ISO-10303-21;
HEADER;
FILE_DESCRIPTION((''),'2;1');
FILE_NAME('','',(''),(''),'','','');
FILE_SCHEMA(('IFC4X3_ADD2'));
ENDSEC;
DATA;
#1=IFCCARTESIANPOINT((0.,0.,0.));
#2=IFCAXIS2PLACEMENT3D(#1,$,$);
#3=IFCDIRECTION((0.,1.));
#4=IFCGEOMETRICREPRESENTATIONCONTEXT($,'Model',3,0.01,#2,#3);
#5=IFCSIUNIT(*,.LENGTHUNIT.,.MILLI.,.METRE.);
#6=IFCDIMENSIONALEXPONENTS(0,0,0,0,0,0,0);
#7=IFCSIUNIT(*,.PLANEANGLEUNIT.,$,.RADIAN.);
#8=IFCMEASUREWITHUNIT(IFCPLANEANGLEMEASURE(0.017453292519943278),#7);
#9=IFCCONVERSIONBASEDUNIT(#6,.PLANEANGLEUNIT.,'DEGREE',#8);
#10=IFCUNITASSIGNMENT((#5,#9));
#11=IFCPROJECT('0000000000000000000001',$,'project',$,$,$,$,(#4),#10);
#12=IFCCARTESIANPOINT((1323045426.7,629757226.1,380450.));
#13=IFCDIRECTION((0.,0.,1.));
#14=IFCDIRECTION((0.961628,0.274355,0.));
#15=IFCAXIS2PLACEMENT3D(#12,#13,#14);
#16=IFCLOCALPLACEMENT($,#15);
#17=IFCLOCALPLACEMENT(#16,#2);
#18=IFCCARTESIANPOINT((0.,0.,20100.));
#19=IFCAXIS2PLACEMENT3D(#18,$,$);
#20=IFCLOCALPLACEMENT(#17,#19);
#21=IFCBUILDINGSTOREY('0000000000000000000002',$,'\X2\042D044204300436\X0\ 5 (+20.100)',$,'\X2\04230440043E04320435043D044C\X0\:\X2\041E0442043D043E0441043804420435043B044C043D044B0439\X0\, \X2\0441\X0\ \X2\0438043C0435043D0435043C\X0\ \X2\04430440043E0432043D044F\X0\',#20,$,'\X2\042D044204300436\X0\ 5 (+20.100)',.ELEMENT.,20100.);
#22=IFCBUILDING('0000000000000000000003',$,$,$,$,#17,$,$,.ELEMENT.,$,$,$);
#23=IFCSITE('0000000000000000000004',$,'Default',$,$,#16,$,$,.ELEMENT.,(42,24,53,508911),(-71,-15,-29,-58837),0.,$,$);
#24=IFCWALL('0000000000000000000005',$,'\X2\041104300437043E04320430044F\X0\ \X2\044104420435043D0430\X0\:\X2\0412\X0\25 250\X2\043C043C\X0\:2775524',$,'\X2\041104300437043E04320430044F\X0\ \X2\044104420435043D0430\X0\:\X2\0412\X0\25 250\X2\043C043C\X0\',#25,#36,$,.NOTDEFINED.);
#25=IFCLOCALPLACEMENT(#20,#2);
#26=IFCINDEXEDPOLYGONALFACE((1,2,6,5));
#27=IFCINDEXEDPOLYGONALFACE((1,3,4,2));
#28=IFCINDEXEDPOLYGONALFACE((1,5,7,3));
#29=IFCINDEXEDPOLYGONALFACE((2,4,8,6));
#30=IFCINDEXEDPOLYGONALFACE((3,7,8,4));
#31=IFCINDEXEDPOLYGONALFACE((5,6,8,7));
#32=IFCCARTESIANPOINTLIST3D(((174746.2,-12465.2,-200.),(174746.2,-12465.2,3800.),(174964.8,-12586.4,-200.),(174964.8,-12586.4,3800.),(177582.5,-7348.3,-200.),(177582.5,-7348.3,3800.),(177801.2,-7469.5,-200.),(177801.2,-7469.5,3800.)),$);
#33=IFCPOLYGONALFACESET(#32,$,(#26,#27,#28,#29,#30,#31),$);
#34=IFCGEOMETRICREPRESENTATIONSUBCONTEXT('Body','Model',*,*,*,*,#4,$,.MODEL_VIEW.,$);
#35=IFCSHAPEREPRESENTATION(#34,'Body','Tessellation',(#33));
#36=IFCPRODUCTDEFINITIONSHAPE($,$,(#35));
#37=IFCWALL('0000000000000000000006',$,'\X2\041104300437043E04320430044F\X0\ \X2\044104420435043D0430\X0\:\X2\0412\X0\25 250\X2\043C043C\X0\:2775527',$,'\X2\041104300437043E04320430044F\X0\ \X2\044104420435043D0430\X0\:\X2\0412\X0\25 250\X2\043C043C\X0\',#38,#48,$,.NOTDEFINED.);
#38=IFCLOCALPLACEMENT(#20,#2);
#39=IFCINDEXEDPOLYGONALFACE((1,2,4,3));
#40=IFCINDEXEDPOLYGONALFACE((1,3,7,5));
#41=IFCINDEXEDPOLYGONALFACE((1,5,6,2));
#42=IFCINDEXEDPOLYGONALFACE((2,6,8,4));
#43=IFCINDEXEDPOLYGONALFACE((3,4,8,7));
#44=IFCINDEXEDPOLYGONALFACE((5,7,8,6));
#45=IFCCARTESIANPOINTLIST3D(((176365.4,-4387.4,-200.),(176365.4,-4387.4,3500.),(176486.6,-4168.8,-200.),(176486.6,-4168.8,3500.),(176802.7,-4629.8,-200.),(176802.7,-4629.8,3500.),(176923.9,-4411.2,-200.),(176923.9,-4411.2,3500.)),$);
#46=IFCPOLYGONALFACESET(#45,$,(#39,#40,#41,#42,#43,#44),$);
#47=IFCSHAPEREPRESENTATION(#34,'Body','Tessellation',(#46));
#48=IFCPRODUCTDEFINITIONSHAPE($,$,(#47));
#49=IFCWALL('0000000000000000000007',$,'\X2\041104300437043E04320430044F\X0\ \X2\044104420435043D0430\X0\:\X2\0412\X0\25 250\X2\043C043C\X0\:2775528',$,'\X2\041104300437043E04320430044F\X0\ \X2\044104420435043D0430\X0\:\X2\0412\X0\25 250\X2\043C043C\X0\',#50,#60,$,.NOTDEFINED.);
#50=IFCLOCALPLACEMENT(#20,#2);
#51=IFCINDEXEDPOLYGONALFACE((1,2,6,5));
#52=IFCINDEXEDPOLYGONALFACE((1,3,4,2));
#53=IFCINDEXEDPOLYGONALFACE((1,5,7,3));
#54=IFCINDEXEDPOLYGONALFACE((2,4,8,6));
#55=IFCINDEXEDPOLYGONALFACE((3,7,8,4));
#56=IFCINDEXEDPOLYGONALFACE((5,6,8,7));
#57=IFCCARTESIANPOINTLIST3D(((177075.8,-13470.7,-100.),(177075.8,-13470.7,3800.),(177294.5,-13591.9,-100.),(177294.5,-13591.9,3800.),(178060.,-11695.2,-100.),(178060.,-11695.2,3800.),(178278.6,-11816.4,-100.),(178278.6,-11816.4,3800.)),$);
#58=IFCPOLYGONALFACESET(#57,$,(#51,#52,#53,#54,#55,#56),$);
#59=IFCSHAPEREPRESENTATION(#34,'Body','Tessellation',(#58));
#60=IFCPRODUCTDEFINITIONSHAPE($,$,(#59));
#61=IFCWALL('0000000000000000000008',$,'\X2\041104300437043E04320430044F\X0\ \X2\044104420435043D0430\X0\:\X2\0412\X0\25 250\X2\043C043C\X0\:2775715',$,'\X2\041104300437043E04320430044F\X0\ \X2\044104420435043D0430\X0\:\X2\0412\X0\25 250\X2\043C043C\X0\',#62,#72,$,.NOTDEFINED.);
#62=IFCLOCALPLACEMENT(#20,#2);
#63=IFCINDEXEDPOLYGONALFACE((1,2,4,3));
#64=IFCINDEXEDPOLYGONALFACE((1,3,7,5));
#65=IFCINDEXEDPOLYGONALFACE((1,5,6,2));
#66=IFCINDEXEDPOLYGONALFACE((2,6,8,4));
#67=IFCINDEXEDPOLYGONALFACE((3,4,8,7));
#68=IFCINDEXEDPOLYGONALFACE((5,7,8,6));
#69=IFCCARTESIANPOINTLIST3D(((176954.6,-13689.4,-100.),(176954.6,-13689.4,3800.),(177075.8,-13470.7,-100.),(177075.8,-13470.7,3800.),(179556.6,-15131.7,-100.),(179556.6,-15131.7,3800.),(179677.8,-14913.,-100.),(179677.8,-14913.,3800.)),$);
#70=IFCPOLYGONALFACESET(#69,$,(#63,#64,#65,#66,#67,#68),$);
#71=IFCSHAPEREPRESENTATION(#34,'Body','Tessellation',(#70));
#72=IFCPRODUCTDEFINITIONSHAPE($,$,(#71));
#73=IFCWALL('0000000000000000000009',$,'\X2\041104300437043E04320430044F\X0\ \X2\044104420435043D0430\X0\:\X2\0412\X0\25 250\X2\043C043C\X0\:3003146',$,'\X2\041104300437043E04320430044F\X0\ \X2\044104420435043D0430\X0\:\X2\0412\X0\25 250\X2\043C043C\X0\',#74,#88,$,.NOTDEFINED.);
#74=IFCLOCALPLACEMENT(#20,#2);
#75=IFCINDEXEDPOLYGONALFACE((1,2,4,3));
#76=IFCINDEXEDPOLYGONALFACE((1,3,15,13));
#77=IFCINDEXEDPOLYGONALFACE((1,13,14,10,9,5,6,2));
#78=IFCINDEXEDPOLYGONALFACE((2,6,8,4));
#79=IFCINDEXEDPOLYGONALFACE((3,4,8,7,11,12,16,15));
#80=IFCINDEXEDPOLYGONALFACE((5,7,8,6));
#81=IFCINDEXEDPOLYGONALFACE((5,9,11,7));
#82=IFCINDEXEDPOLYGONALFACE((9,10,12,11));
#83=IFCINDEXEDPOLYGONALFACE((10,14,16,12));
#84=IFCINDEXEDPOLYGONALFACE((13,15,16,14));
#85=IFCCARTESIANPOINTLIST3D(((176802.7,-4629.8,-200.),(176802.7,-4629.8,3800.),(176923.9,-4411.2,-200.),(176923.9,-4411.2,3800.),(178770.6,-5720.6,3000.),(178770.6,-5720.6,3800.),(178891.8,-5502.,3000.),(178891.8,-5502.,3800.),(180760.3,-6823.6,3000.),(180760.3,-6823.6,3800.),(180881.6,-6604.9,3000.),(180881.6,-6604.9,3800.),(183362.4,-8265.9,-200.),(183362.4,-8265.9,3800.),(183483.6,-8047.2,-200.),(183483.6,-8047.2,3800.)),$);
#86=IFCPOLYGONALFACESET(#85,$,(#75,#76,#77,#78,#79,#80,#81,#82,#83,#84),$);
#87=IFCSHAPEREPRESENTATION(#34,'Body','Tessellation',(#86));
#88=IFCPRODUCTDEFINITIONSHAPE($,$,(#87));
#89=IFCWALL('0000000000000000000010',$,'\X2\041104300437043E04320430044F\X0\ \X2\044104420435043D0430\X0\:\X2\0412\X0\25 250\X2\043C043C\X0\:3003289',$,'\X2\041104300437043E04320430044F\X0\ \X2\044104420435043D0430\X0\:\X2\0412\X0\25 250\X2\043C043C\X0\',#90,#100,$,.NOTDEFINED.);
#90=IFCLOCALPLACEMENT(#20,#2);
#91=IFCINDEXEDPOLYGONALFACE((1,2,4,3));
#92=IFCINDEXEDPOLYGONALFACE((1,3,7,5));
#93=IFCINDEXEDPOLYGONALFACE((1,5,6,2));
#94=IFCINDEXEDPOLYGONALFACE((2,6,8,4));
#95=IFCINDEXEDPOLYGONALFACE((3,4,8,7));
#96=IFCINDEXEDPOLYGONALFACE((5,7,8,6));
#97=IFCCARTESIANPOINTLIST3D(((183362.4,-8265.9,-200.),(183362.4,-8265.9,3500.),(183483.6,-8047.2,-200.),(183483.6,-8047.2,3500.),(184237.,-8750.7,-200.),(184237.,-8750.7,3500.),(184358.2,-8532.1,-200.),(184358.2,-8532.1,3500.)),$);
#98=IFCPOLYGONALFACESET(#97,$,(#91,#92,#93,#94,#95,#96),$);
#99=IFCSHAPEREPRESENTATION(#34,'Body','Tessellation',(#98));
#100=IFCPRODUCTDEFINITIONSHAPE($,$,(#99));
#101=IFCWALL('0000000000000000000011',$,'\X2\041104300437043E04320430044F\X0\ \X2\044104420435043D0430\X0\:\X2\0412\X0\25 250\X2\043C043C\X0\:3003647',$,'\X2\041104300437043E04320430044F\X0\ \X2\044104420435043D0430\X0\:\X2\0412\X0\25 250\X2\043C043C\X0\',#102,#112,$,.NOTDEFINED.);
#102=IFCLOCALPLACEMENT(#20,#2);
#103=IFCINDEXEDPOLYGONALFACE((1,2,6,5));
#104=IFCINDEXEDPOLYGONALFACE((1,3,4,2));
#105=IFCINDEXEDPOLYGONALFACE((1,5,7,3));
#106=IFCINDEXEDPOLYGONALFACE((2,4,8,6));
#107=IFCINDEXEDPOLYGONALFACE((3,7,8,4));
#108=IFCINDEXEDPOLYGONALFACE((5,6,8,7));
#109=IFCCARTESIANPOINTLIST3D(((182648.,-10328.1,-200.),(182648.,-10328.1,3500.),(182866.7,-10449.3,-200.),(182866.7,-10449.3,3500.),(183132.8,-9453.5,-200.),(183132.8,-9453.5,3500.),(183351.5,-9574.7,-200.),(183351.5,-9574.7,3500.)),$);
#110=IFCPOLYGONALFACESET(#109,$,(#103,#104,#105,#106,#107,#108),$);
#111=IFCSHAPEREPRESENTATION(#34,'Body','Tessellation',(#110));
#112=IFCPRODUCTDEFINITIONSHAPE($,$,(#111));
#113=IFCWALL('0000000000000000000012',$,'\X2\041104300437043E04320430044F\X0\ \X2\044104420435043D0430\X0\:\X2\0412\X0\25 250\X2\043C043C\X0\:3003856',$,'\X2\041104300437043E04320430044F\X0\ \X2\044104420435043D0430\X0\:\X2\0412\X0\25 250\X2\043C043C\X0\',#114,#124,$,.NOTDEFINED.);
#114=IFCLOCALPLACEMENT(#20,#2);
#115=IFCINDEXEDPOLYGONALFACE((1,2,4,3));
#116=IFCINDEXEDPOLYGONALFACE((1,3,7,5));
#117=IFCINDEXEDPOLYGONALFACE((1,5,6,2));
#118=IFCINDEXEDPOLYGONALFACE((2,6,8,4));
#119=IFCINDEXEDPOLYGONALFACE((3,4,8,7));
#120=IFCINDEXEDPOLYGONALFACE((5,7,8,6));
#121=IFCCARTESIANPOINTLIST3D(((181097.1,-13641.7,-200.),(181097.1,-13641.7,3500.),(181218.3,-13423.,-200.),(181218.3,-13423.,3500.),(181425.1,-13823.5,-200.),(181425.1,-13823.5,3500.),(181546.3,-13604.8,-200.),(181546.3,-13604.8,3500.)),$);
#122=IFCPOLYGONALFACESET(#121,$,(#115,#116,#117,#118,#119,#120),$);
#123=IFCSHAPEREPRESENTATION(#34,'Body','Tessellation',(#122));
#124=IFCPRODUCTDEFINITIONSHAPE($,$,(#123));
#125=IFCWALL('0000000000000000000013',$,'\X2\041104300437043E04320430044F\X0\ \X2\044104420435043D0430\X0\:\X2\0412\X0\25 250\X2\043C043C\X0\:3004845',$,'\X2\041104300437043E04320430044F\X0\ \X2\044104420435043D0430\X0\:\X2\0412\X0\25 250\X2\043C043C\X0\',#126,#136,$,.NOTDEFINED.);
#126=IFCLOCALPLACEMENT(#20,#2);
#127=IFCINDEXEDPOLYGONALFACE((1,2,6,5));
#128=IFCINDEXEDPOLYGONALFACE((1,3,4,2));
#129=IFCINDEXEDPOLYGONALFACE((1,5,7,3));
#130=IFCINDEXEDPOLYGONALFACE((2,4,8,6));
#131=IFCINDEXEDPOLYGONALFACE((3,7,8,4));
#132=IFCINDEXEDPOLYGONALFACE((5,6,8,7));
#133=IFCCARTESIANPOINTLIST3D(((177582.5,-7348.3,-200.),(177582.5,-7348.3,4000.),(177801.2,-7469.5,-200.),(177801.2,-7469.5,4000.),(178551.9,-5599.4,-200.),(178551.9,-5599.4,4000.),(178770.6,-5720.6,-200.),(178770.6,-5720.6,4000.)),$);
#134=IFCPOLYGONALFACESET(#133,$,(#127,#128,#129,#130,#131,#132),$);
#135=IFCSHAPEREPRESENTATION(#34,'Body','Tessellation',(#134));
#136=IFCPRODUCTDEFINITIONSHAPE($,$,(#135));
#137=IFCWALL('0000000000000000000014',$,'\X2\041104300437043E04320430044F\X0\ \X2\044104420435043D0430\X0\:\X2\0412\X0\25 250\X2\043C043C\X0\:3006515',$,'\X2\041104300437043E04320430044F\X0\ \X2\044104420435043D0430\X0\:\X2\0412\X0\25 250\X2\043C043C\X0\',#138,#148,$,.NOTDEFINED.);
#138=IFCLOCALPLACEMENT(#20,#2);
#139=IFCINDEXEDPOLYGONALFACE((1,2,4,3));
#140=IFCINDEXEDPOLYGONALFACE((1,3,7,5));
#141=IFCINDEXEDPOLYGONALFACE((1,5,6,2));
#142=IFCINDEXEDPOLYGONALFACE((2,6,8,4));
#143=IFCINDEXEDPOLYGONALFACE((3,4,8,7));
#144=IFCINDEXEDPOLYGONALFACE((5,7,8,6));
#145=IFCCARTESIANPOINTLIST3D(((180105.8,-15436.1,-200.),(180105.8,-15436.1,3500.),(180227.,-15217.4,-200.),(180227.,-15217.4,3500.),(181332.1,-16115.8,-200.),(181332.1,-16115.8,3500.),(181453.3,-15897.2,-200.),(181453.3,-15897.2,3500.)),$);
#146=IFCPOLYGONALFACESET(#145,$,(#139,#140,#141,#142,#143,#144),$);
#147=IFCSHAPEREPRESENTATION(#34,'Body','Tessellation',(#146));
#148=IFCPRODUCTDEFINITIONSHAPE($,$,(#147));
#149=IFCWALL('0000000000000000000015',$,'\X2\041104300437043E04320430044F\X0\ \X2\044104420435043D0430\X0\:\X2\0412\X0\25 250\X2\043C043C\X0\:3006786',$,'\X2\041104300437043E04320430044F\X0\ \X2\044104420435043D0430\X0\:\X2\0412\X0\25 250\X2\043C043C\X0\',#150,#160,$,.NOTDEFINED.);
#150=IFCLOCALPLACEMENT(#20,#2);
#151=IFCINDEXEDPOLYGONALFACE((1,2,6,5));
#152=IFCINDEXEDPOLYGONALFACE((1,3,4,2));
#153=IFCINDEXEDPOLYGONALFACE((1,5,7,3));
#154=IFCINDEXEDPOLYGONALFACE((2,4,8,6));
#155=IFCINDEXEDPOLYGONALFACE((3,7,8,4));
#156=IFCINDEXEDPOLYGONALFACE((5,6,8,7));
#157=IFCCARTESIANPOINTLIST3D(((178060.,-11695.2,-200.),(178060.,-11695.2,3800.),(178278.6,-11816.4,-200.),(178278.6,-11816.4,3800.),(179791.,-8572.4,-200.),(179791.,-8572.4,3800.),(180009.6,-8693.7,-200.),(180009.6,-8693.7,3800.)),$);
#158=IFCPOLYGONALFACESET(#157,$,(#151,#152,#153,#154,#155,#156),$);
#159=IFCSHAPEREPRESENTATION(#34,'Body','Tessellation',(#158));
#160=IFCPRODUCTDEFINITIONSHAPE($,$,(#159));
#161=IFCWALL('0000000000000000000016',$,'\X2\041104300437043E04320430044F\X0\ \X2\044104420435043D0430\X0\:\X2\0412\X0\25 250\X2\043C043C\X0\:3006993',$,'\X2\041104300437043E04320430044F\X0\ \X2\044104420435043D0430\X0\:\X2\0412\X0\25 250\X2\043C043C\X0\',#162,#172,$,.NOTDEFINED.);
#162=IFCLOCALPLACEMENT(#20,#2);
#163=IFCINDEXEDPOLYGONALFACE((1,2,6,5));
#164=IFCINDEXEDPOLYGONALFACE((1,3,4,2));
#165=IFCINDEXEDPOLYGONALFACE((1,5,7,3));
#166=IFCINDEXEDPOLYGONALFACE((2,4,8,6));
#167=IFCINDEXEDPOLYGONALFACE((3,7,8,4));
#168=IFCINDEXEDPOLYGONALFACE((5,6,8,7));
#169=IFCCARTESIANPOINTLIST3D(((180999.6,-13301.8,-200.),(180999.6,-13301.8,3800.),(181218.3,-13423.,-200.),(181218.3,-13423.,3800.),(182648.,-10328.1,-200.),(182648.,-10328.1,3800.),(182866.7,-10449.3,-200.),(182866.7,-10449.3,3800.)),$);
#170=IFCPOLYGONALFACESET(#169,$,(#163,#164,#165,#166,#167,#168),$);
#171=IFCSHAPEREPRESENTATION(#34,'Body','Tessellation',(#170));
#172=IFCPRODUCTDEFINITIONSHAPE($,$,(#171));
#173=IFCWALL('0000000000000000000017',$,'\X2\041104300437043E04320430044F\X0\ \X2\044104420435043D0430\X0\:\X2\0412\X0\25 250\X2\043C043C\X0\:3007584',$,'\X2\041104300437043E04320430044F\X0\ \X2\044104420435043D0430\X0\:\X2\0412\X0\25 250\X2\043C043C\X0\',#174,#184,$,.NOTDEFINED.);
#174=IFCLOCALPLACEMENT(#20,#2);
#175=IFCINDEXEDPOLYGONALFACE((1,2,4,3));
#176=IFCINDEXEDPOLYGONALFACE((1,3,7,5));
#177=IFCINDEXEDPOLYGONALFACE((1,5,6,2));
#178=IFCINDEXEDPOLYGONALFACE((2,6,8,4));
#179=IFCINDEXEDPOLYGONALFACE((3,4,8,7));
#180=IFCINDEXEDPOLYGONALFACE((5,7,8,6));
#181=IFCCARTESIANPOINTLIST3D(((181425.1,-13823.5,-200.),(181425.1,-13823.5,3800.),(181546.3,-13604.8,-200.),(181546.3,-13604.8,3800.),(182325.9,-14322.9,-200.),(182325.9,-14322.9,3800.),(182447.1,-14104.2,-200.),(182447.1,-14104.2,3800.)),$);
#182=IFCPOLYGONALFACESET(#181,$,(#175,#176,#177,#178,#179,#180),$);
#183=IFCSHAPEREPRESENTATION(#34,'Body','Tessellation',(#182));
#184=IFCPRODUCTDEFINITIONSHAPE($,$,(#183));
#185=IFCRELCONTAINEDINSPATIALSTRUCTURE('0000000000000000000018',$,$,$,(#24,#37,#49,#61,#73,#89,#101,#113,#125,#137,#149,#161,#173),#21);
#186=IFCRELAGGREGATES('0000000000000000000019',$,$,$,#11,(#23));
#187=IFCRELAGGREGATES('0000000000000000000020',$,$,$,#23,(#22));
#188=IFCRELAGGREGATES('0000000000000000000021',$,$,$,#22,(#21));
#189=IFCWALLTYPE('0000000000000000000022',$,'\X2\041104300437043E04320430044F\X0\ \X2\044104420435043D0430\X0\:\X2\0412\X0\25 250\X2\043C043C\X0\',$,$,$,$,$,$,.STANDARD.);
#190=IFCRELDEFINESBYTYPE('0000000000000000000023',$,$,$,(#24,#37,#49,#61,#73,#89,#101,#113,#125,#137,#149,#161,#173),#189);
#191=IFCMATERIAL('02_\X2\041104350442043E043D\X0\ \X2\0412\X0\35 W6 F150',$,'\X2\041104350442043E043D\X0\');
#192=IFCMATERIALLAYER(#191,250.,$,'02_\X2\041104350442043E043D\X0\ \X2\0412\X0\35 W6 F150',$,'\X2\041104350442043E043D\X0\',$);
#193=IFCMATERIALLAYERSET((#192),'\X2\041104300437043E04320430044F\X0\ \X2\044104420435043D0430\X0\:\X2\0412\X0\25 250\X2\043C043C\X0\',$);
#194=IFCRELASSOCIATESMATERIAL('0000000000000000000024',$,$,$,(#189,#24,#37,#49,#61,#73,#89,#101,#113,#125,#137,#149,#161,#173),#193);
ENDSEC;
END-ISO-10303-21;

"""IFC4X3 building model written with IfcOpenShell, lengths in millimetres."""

from ifc_helpers import new_model, entity, si_unit, converted_unit, direction, frame, frame_2d, origin, place, context, subcontext, project, spatial, polyline, rectangle, extrude, clip, bounded_halfspace, material, layer, layer_set, type_object, element, save


model = new_model("IFC4X3")

# Units and contexts
model_context = context("Model", 3, precision=0.01, world=origin(), true_north=direction((0.0, 1.0)))
body_context = subcontext(model_context, "Body", "Model", "MODEL_VIEW")
ifc_project = project(units=[si_unit("LENGTHUNIT", "METRE", prefix="MILLI"), converted_unit("PLANEANGLEUNIT", "DEGREE", entity("IfcPlaneAngleMeasure", 0.017453292519943278), si_unit("PLANEANGLEUNIT", "RADIAN"), dimensions=[0, 0, 0, 0, 0, 0, 0])], contexts=[model_context])

# Site, building, storey
site_placement = place(None, frame((1323045426.7, 629757226.1, 380450.0), z_axis=(0.0, 0.0, 1.0), x_axis=(0.961628, 0.274355, 0.0)))
site = spatial("IfcSite", under=ifc_project, at=site_placement, Name="Default", CompositionType="ELEMENT", RefLatitude=(42, 24, 53, 508911), RefLongitude=(-71, -15, -29, -58837), RefElevation=0.0)
building_placement = place(site_placement, origin())
building = spatial("IfcBuilding", under=site, at=building_placement, CompositionType="ELEMENT")
storey_placement = place(building_placement, frame((0.0, 0.0, 20100.0)))
storey = spatial("IfcBuildingStorey", under=building, at=storey_placement, Name="Этаж 5 (+20.100)", ObjectType="Уровень:Относительный, с именем уровня", LongName="Этаж 5 (+20.100)", CompositionType="ELEMENT", Elevation=20100.0)

# Walls
ifc_material_1 = material(Name="02_Бетон В35 W6 F150", Category="Бетон")
ifc_layer_1 = layer(ifc_material_1, 250.0, Name="02_Бетон В35 W6 F150", Category="Бетон")
ifc_layer_set_1 = layer_set([ifc_layer_1], Name="Базовая стена:В25 250мм")
wall_type_1 = type_object("IfcWallType", Name="Базовая стена:В25 250мм", PredefinedType="STANDARD", material=ifc_layer_set_1)
wall_1_placement = place(storey_placement, frame((174855.5, -12525.8, -200.0), z_axis=(0.0, 0.0, 1.0), x_axis=(0.48481, 0.87462, 0.0)))
element("IfcWall", 1, at=wall_1_placement, inside=storey, type_object=wall_type_1, material=ifc_layer_set_1, Name="Базовая стена:В25 250мм:2775524", ObjectType="Базовая стена:В25 250мм", PredefinedType="NOTDEFINED", context=body_context, shape_type="SweptSolid", body=[
    extrude(rectangle(XDim=5850.4, YDim=250.0, at=frame_2d((2925.2, 0.0), x_axis=(-1.0, 0.0))), origin(), (0.0, 0.0, 1.0), 4000.0),
])
wall_2_placement = place(storey_placement, frame((176426.0, -4278.1, -200.0), z_axis=(0.0, 0.0, 1.0), x_axis=(0.87462, -0.48481, 0.0)))
element("IfcWall", 2, at=wall_2_placement, inside=storey, type_object=wall_type_1, material=ifc_layer_set_1, Name="Базовая стена:В25 250мм:2775527", ObjectType="Базовая стена:В25 250мм", PredefinedType="NOTDEFINED", context=body_context, shape_type="SweptSolid", body=[
    extrude(rectangle(XDim=500.0, YDim=250.0, at=frame_2d((250.0, 0.0), x_axis=(-1.0, 0.0))), origin(), (0.0, 0.0, 1.0), 3700.0),
])
wall_3_placement = place(storey_placement, frame((177185.1, -13531.3, -100.0), z_axis=(0.0, 0.0, 1.0), x_axis=(0.48481, 0.87462, 0.0)))
element("IfcWall", 3, at=wall_3_placement, inside=storey, type_object=wall_type_1, material=ifc_layer_set_1, Name="Базовая стена:В25 250мм:2775528", ObjectType="Базовая стена:В25 250мм", PredefinedType="NOTDEFINED", context=body_context, shape_type="SweptSolid", body=[
    extrude(rectangle(XDim=2030.0, YDim=250.0, at=frame_2d((1015.0, 0.0), x_axis=(-1.0, 0.0))), origin(), (0.0, 0.0, 1.0), 3900.0),
])
wall_4_placement = place(storey_placement, frame((177015.2, -13580.0, -100.0), z_axis=(0.0, 0.0, 1.0), x_axis=(0.87462, -0.48481, 0.0)))
element("IfcWall", 4, at=wall_4_placement, inside=storey, type_object=wall_type_1, material=ifc_layer_set_1, Name="Базовая стена:В25 250мм:2775715", ObjectType="Базовая стена:В25 250мм", PredefinedType="NOTDEFINED", context=body_context, shape_type="SweptSolid", body=[
    extrude(rectangle(XDim=2975.0, YDim=250.0, at=frame_2d((1487.5, 0.0), x_axis=(-1.0, 0.0))), origin(), (0.0, 0.0, 1.0), 3900.0),
])

# Wall, opening
wall_5_placement = place(storey_placement, frame((176863.3, -4520.5, -200.0), z_axis=(0.0, 0.0, 1.0), x_axis=(0.87462, -0.48481, 0.0)))
wall_5 = element("IfcWall", 5, at=wall_5_placement, inside=storey, type_object=wall_type_1, material=ifc_layer_set_1, Name="Базовая стена:В25 250мм:3003146", ObjectType="Базовая стена:В25 250мм", PredefinedType="NOTDEFINED", context=body_context, shape_type="SweptSolid", body=[
    extrude(rectangle(XDim=7500.0, YDim=250.0, at=frame_2d((3750.0, 0.0), x_axis=(-1.0, 0.0))), origin(), (0.0, 0.0, 1.0), 4000.0),
])
opening_1_placement = place(wall_5_placement, frame((-156879.7, -81791.3, 3200.0), z_axis=(0.0, 0.0, 1.0), x_axis=(0.87462, 0.48481, 0.0)))
element("IfcOpeningElement", 6, at=opening_1_placement, cuts=wall_5, PredefinedType="OPENING", context=body_context, shape_type="SweptSolid", body=[
    extrude(rectangle(XDim=800.0, YDim=2275.0, at=frame_2d((0.0, 0.0), x_axis=(1.0, 0.0))), frame((179147.8, -7386.4, 400.0), z_axis=(0.48481, 0.87462, 0.0), x_axis=(0.0, 0.0, -1.0)), (0.0, 0.0, 1.0), 3048.0),
])

# Wall
wall_6_placement = place(storey_placement, frame((183423.0, -8156.6, -200.0), z_axis=(0.0, 0.0, 1.0), x_axis=(0.87462, -0.48481, 0.0)))
element("IfcWall", 7, at=wall_6_placement, inside=storey, type_object=wall_type_1, material=ifc_layer_set_1, Name="Базовая стена:В25 250мм:3003289", ObjectType="Базовая стена:В25 250мм", PredefinedType="NOTDEFINED", context=body_context, shape_type="SweptSolid", body=[
    extrude(rectangle(XDim=1000.0, YDim=250.0, at=frame_2d((500.0, 0.0), x_axis=(-1.0, 0.0))), origin(), (0.0, 0.0, 1.0), 3700.0),
])

# Walls
wall_7_placement = place(storey_placement, frame((182757.3, -10388.7, -200.0), z_axis=(0.0, 0.0, 1.0), x_axis=(0.48481, 0.87462, 0.0)))
element("IfcWall", 8, at=wall_7_placement, inside=storey, type_object=wall_type_1, material=ifc_layer_set_1, Name="Базовая стена:В25 250мм:3003647", ObjectType="Базовая стена:В25 250мм", PredefinedType="NOTDEFINED", context=body_context, shape_type="SweptSolid", body=[
    extrude(rectangle(XDim=1000.0, YDim=250.0, at=frame_2d((500.0, 0.0), x_axis=(-1.0, 0.0))), origin(), (0.0, 0.0, 1.0), 3700.0),
])
wall_8_placement = place(storey_placement, frame((181157.7, -13532.4, -200.0), z_axis=(0.0, 0.0, 1.0), x_axis=(0.87462, -0.48481, 0.0)))
element("IfcWall", 9, at=wall_8_placement, inside=storey, type_object=wall_type_1, material=ifc_layer_set_1, Name="Базовая стена:В25 250мм:3003856", ObjectType="Базовая стена:В25 250мм", PredefinedType="NOTDEFINED", context=body_context, shape_type="SweptSolid", body=[
    extrude(rectangle(XDim=375.0, YDim=250.0, at=frame_2d((187.5, 0.0), x_axis=(-1.0, 0.0))), origin(), (0.0, 0.0, 1.0), 3700.0),
])

# Wall
wall_9_placement = place(storey_placement, frame((177691.9, -7408.9, -200.0), z_axis=(0.0, 0.0, 1.0), x_axis=(0.48481, 0.87462, 0.0)))
element("IfcWall", 10, at=wall_9_placement, inside=storey, type_object=wall_type_1, material=ifc_layer_set_1, Name="Базовая стена:В25 250мм:3004845", ObjectType="Базовая стена:В25 250мм", PredefinedType="NOTDEFINED", context=body_context, shape_type="SweptSolid", body=[
    extrude(rectangle(XDim=1999.6, YDim=250.0, at=frame_2d((999.8, 0.0), x_axis=(-1.0, 0.0))), origin(), (0.0, 0.0, 1.0), 4200.0),
])

# Walls
wall_10_placement = place(storey_placement, frame((180166.4, -15326.7, -200.0), z_axis=(0.0, 0.0, 1.0), x_axis=(0.87462, -0.48481, 0.0)))
element("IfcWall", 11, at=wall_10_placement, inside=storey, type_object=wall_type_1, material=ifc_layer_set_1, Name="Базовая стена:В25 250мм:3006515", ObjectType="Базовая стена:В25 250мм", PredefinedType="NOTDEFINED", context=body_context, shape_type="SweptSolid", body=[
    extrude(rectangle(XDim=1402.1, YDim=250.0, at=frame_2d((701.1, 0.0), x_axis=(-1.0, 0.0))), origin(), (0.0, 0.0, 1.0), 3700.0),
])
wall_11_placement = place(storey_placement, frame((178169.3, -11755.8, -200.0), z_axis=(0.0, 0.0, 1.0), x_axis=(0.48481, 0.87462, 0.0)))
element("IfcWall", 12, at=wall_11_placement, inside=storey, type_object=wall_type_1, material=ifc_layer_set_1, Name="Базовая стена:В25 250мм:3006786", ObjectType="Базовая стена:В25 250мм", PredefinedType="NOTDEFINED", context=body_context, shape_type="Clipping", body=[
    clip(extrude(rectangle(XDim=3570.4, YDim=250.0, at=frame_2d((1785.2, 0.0), x_axis=(-1.0, 0.0))), origin(), (0.0, 0.0, 1.0), 4000.0), bounded_halfspace(frame((0.0, -125.0, 4000.0), z_axis=(0.0, 0.0, -1.0), x_axis=(-0.87462, -0.48481, 0.0)), True, frame((0.0, -125.0, 4000.0), z_axis=(0.0, 0.0, -1.0), x_axis=(-0.87462, -0.48481, 0.0)), polyline([(0.0, 0.0), (-121.2, 218.7), (-3244.0, -1512.3), (-3122.8, -1731.0), (0.0, 0.0)]))),
])
wall_12_placement = place(storey_placement, frame((181109.0, -13362.4, -200.0), z_axis=(0.0, 0.0, 1.0), x_axis=(0.48481, 0.87462, 0.0)))
element("IfcWall", 13, at=wall_12_placement, inside=storey, type_object=wall_type_1, material=ifc_layer_set_1, Name="Базовая стена:В25 250мм:3006993", ObjectType="Базовая стена:В25 250мм", PredefinedType="NOTDEFINED", context=body_context, shape_type="SweptSolid", body=[
    extrude(rectangle(XDim=3400.0, YDim=250.0, at=frame_2d((1700.0, 0.0), x_axis=(-1.0, 0.0))), origin(), (0.0, 0.0, 1.0), 4000.0),
])
wall_13_placement = place(storey_placement, frame((181485.7, -13714.2, -200.0), z_axis=(0.0, 0.0, 1.0), x_axis=(0.87462, -0.48481, 0.0)))
element("IfcWall", 14, at=wall_13_placement, inside=storey, type_object=wall_type_1, material=ifc_layer_set_1, Name="Базовая стена:В25 250мм:3007584", ObjectType="Базовая стена:В25 250мм", PredefinedType="NOTDEFINED", context=body_context, shape_type="SweptSolid", body=[
    extrude(rectangle(XDim=1030.0, YDim=250.0, at=frame_2d((515.0, 0.0), x_axis=(-1.0, 0.0))), origin(), (0.0, 0.0, 1.0), 4000.0),
])

save(model, "model.ifc")
